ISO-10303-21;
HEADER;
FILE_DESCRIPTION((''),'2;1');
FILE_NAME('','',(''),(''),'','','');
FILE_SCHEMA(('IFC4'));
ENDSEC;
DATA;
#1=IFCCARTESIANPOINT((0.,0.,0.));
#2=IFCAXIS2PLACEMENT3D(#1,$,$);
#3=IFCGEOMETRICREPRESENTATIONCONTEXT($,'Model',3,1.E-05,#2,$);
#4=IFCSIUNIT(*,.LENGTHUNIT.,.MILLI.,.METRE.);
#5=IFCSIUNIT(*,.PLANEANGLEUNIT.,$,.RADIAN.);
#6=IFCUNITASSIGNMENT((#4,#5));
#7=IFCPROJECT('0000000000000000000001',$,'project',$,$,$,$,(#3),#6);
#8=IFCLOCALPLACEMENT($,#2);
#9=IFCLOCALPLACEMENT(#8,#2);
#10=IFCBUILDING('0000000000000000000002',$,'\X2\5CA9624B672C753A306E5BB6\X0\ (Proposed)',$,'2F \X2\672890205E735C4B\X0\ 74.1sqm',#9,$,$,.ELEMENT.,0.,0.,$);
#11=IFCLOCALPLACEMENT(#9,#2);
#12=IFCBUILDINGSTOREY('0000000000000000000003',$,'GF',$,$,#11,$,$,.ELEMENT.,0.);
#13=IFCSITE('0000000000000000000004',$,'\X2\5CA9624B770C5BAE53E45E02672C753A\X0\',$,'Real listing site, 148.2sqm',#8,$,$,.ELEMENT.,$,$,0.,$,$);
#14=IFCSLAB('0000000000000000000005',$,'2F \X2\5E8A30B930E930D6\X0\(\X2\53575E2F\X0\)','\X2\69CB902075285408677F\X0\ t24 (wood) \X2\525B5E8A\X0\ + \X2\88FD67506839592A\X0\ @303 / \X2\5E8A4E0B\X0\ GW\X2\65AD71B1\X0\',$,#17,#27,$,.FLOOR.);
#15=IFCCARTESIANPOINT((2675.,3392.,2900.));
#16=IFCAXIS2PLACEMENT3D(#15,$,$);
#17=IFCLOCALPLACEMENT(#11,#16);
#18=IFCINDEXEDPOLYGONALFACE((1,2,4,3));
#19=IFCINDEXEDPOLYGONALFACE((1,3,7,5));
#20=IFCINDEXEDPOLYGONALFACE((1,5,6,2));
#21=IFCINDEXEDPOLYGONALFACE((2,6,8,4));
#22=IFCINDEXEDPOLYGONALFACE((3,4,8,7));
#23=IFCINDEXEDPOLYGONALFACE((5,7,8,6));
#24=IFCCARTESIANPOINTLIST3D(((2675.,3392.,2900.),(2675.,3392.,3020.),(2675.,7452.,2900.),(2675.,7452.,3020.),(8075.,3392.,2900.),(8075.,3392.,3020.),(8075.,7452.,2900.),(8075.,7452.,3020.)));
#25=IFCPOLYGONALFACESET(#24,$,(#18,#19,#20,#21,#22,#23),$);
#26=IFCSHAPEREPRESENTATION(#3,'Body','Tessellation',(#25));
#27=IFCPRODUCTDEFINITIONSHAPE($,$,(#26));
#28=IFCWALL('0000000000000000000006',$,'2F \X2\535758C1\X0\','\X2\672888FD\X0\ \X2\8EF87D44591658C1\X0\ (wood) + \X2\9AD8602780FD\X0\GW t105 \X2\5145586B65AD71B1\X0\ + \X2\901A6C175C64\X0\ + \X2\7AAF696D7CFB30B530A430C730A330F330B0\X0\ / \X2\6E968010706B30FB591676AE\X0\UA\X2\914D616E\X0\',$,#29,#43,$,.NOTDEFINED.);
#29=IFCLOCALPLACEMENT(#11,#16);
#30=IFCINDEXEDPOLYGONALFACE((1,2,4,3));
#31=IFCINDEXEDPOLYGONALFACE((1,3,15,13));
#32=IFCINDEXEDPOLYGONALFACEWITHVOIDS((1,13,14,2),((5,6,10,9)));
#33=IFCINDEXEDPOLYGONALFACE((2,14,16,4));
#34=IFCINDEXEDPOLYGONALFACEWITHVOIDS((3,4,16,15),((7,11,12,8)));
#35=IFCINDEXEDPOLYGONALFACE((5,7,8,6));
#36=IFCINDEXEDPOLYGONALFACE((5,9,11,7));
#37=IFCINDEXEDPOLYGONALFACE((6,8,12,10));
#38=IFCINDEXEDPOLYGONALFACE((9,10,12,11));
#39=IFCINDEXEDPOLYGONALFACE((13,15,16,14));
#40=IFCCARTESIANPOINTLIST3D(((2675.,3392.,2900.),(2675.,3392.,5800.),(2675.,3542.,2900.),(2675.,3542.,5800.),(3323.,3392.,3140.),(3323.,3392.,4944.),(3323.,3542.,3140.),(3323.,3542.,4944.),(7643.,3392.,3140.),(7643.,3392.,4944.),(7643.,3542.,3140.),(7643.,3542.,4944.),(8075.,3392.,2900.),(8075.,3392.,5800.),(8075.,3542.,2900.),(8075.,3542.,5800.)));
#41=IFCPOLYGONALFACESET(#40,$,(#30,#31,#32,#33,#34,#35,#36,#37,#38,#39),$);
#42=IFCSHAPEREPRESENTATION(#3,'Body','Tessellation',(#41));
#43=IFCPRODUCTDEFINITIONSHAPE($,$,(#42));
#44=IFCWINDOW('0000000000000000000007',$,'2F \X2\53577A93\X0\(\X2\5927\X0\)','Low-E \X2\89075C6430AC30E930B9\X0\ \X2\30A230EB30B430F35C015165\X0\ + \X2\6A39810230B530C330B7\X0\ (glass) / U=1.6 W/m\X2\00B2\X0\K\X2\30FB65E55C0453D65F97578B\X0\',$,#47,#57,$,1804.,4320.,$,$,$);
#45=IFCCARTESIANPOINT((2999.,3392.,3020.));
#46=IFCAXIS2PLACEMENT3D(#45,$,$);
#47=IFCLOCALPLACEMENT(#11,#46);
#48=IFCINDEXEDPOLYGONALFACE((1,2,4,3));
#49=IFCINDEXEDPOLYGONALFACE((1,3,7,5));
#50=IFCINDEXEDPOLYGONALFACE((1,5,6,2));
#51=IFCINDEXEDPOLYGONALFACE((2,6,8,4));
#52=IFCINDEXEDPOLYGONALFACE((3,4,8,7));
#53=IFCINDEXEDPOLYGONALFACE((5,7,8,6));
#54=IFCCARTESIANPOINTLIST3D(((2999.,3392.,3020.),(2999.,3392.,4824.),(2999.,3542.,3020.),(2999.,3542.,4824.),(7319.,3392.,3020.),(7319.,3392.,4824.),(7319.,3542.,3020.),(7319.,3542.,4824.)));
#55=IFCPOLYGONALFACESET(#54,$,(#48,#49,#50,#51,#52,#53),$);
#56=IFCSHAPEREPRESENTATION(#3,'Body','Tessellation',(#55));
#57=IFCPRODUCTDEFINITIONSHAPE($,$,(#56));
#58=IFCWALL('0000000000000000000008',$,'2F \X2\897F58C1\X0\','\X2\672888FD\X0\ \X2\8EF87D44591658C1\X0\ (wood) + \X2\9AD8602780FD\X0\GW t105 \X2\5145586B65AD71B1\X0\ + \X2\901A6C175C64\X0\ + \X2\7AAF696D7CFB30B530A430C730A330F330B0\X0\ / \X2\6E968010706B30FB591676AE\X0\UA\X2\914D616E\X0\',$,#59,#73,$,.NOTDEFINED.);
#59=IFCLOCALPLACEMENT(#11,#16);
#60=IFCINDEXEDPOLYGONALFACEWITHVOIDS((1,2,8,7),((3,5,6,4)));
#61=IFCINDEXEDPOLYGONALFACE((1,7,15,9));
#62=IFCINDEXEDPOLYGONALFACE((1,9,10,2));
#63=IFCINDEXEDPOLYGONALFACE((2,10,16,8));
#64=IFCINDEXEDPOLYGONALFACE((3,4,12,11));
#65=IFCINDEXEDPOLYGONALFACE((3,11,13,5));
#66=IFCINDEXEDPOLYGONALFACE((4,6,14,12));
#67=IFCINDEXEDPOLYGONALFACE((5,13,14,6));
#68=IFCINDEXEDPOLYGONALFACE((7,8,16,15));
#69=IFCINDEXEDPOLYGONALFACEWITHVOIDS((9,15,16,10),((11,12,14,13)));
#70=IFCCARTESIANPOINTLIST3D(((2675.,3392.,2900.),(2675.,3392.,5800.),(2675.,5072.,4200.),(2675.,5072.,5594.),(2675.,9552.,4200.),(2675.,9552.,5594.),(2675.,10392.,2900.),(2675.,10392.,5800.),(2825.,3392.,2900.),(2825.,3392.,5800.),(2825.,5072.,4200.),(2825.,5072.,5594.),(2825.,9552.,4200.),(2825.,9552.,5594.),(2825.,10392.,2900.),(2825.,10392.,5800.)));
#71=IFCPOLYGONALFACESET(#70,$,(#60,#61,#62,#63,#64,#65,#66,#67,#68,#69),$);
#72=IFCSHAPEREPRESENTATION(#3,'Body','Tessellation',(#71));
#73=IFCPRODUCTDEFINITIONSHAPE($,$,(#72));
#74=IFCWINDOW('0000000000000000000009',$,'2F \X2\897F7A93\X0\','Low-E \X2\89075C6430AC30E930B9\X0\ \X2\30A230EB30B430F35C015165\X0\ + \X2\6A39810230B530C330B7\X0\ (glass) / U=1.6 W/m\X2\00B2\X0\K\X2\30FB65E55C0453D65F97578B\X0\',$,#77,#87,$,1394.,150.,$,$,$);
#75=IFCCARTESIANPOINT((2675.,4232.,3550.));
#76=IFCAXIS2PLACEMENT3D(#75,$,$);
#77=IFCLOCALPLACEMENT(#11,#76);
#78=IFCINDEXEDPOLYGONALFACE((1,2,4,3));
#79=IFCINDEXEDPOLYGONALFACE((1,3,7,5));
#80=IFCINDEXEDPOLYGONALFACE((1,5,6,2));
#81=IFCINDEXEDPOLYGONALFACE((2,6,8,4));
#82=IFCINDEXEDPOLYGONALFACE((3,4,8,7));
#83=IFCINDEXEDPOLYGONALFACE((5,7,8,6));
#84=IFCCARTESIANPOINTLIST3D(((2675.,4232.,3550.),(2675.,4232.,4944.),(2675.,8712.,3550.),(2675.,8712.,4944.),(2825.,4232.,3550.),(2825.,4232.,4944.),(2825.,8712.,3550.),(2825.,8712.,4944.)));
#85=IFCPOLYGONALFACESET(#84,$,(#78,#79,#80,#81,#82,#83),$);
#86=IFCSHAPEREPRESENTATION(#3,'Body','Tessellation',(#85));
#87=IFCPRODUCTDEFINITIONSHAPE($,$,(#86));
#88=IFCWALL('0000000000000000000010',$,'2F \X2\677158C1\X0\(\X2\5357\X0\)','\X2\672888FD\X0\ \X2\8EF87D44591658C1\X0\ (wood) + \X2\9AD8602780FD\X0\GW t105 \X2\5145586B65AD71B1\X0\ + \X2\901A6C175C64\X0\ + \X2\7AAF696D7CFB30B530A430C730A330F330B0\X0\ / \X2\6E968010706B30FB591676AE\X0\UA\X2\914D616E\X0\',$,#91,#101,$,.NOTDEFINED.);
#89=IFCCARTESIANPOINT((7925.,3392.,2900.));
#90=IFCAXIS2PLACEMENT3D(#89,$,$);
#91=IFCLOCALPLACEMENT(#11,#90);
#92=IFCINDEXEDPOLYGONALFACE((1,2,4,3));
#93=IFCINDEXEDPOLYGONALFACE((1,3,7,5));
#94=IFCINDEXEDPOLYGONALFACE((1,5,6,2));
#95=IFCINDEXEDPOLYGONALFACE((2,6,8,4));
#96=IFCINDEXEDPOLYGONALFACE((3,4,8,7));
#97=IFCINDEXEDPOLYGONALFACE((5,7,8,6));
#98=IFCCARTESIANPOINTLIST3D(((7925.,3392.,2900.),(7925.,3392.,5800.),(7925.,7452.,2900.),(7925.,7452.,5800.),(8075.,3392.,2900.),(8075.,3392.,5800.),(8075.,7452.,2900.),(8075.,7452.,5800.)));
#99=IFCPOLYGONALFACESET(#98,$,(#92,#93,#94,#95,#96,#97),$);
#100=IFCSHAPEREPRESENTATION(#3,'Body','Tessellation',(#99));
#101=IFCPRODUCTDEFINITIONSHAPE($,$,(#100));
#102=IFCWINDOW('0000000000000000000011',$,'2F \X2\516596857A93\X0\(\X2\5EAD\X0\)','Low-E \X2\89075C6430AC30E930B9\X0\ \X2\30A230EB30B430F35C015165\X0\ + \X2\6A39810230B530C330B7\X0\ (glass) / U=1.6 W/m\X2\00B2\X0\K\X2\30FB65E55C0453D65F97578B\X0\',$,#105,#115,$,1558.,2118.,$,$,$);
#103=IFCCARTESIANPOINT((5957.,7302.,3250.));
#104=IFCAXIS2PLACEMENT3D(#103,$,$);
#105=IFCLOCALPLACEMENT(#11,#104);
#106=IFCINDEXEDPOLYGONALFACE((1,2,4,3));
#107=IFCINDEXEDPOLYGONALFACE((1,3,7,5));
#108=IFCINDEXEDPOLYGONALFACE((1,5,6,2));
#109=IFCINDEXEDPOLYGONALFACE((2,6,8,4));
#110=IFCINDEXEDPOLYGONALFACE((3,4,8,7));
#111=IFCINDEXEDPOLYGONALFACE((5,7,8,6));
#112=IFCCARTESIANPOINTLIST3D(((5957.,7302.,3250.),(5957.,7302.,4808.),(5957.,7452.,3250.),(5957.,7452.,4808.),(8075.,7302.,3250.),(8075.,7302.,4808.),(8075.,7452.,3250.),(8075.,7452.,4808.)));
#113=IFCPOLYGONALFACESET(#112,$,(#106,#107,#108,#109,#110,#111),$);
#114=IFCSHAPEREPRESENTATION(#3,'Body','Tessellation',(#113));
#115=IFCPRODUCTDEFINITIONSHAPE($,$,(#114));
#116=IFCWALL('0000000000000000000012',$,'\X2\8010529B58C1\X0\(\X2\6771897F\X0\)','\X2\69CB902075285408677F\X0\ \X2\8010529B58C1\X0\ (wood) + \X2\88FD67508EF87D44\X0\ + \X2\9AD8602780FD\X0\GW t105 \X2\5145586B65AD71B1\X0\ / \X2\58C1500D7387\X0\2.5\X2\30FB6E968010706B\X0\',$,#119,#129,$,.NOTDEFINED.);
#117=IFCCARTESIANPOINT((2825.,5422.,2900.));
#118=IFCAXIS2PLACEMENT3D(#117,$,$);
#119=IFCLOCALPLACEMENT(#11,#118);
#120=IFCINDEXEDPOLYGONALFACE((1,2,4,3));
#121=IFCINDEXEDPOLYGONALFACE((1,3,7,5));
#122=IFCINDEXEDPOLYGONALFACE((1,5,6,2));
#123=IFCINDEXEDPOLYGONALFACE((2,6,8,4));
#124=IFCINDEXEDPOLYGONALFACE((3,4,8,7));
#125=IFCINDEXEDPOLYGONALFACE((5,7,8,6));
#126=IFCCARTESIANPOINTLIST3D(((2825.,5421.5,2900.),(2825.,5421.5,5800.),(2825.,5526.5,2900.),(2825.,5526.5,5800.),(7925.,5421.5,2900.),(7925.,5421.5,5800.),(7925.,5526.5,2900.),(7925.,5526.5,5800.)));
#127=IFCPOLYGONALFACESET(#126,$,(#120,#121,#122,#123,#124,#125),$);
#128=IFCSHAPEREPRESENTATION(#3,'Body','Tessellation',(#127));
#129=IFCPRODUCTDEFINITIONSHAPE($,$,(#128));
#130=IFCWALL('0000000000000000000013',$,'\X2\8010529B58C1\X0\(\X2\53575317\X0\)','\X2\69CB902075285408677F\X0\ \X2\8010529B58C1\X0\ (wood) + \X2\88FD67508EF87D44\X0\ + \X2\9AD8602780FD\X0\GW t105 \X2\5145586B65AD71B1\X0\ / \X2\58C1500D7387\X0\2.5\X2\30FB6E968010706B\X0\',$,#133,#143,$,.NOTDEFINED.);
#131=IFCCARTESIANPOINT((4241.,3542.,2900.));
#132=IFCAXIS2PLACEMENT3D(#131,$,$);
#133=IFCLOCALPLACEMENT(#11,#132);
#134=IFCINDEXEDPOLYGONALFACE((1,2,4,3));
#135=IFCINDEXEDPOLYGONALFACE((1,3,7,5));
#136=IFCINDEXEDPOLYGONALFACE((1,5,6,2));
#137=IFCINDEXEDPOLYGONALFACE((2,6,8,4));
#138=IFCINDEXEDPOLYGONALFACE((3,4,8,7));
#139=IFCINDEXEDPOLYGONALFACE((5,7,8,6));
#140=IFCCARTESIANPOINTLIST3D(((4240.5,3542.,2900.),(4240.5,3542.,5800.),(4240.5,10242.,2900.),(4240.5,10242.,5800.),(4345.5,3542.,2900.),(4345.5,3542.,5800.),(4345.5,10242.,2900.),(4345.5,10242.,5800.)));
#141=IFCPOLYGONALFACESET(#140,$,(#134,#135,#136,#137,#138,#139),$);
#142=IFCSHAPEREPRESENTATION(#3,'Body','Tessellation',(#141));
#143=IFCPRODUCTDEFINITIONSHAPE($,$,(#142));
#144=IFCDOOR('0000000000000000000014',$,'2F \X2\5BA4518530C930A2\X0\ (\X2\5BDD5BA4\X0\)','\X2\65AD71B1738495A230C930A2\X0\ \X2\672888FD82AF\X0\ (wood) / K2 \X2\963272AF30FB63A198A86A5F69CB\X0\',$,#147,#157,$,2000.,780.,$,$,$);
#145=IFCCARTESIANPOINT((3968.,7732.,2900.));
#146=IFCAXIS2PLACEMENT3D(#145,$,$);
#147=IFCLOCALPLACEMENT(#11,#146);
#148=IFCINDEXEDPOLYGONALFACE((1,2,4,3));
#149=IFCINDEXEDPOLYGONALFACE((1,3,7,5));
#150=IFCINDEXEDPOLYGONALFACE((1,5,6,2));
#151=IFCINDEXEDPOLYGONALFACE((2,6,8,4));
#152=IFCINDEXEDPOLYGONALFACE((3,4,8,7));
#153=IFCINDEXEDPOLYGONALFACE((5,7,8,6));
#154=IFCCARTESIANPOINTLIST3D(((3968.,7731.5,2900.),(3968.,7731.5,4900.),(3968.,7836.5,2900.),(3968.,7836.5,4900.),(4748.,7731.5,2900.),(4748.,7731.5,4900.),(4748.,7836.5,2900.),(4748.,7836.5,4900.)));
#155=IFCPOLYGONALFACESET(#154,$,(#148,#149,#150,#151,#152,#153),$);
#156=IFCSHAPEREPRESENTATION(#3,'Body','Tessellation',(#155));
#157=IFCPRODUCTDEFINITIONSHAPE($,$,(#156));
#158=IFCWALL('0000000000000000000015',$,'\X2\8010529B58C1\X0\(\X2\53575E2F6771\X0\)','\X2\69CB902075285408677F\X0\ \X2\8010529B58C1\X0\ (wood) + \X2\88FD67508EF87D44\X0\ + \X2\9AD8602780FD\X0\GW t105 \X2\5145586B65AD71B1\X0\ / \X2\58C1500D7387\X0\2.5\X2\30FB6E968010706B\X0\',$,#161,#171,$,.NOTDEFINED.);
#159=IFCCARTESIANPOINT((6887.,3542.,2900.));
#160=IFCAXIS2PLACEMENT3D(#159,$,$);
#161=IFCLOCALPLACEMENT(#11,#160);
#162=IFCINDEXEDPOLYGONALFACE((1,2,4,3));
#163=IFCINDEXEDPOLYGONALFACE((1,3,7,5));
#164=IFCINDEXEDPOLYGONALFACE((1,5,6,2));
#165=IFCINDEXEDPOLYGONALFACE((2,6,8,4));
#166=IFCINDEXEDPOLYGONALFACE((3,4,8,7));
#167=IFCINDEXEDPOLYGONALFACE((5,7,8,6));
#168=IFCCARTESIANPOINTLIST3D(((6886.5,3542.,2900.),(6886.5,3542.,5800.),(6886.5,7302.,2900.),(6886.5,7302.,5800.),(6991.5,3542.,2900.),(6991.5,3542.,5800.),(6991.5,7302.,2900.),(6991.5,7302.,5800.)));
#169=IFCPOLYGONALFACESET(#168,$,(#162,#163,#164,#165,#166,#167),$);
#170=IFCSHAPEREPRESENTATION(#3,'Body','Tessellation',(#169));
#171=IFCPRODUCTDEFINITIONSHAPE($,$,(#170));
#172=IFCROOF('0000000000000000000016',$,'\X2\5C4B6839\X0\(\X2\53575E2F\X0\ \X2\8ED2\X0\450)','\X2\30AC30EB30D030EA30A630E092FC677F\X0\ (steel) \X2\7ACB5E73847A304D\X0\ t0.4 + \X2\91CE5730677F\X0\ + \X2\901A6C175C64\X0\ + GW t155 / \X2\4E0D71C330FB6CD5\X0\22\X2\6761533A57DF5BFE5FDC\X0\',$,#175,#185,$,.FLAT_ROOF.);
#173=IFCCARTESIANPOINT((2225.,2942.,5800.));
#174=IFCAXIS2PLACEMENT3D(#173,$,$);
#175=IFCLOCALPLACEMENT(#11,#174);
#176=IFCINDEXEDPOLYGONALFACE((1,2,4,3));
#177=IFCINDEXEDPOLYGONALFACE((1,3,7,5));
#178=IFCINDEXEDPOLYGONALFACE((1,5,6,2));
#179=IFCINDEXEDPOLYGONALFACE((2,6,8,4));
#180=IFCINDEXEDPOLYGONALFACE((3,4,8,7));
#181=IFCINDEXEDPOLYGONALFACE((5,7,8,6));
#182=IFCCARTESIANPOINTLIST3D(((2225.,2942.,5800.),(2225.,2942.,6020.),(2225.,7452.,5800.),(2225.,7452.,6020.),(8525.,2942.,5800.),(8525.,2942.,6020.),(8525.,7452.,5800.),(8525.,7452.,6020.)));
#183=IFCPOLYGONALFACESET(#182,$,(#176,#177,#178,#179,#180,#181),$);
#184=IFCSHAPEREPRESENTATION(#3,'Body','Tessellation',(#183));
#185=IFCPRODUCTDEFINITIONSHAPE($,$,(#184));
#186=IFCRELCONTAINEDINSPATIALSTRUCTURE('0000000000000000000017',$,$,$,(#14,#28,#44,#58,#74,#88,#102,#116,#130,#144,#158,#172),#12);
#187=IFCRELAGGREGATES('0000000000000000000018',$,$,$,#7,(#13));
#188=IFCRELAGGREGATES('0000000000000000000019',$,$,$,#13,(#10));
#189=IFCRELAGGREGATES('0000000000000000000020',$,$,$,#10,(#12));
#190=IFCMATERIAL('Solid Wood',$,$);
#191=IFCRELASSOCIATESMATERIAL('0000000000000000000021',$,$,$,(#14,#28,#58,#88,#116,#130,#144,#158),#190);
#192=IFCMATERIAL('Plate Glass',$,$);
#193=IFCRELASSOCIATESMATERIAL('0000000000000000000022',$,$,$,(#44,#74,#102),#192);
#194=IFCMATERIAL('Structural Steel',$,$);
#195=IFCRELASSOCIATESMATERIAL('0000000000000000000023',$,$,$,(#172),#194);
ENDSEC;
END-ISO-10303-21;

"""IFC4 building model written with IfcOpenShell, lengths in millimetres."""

from ifc_helpers import new_model, si_unit, frame, frame_2d, origin, place, context, project, spatial, rectangle, extrude, material, element, fill, save


model = new_model("IFC4")

# Units and contexts
model_context = context("Model", 3, precision=1e-05, world=origin())
ifc_project = project(units=[si_unit("LENGTHUNIT", "METRE", prefix="MILLI"), si_unit("PLANEANGLEUNIT", "RADIAN")], contexts=[model_context])

# Site, building, storey
site_placement = place(None, origin())
site = spatial("IfcSite", under=ifc_project, at=site_placement, Name="岩手県宮古市本町", ObjectType="Real listing site, 148.2sqm", CompositionType="ELEMENT", RefElevation=0.0)
building_placement = place(site_placement, origin())
building = spatial("IfcBuilding", under=site, at=building_placement, Name="岩手本町の家 (Proposed)", ObjectType="2F 木造平屋 74.1sqm", CompositionType="ELEMENT", ElevationOfRefHeight=0.0, ElevationOfTerrain=0.0)
storey_placement = place(building_placement, origin())
storey = spatial("IfcBuildingStorey", under=building, at=storey_placement, Name="GF", CompositionType="ELEMENT", Elevation=0.0)

# Slab
ifc_material_1 = material(Name="Solid Wood")
slab_placement = place(storey_placement, frame((2675.0, 3392.0, 2900.0)))
element("IfcSlab", 1, at=slab_placement, inside=storey, material=ifc_material_1, Name="2F 床スラブ(南帯)", Description="構造用合板 t24 (wood) 剛床 + 製材根太 @303 / 床下 GW断熱", PredefinedType="FLOOR", context=model_context, shape_type="SweptSolid", body=[
    extrude(rectangle(XDim=5400.0, YDim=4060.0, at=frame_2d((2700.0, 2030.0))), frame((2675.0, 3392.0, 2900.0)), (0.0, 0.0, 1.0), 120.0),
])

# Walls, openings, windows
wall_1_placement = place(storey_placement, frame((2675.0, 3392.0, 2900.0)))
wall_1 = element("IfcWall", 2, at=wall_1_placement, inside=storey, material=ifc_material_1, Name="2F 南壁", Description="木製 軸組外壁 (wood) + 高性能GW t105 充填断熱 + 通気層 + 窯業系サイディング / 準耐火・外皮UA配慮", PredefinedType="NOTDEFINED", context=model_context, shape_type="SweptSolid", body=[
    extrude(rectangle(XDim=5400.0, YDim=150.0, at=frame_2d((2700.0, 75.0))), frame((2675.0, 3392.0, 2900.0)), (0.0, 0.0, 1.0), 2900.0),
])
opening_1_placement = place(storey_placement, frame((2999.0, 3392.0, 3020.0)))
opening_1 = element("IfcOpeningElement", 3, at=opening_1_placement, cuts=wall_1, PredefinedType="NOTDEFINED", context=model_context, shape_type="SweptSolid", body=[
    extrude(rectangle(XDim=4320.0, YDim=150.0, at=frame_2d((2160.0, 75.0))), frame((2999.0, 3392.0, 3020.0)), (0.0, 0.0, 1.0), 1804.0),
])
ifc_material_2 = material(Name="Plate Glass")
window_1_placement = place(storey_placement, frame((2999.0, 3392.0, 3020.0)))
window_1 = element("IfcWindow", 4, at=window_1_placement, inside=storey, material=ifc_material_2, Name="2F 南窓(大)", Description="Low-E 複層ガラス アルゴン封入 + 樹脂サッシ (glass) / U=1.6 W/m²K・日射取得型", OverallHeight=1804.0, OverallWidth=4320.0, context=model_context, shape_type="SweptSolid", body=[
    extrude(rectangle(XDim=4320.0, YDim=150.0, at=frame_2d((2160.0, 75.0))), frame((2999.0, 3392.0, 3020.0)), (0.0, 0.0, 1.0), 1804.0),
])
fill(opening_1, window_1)
wall_2_placement = place(storey_placement, frame((2675.0, 3392.0, 2900.0)))
wall_2 = element("IfcWall", 5, at=wall_2_placement, inside=storey, material=ifc_material_1, Name="2F 西壁", Description="木製 軸組外壁 (wood) + 高性能GW t105 充填断熱 + 通気層 + 窯業系サイディング / 準耐火・外皮UA配慮", PredefinedType="NOTDEFINED", context=model_context, shape_type="SweptSolid", body=[
    extrude(rectangle(XDim=150.0, YDim=7000.0, at=frame_2d((75.0, 3500.0))), frame((2675.0, 3392.0, 2900.0)), (0.0, 0.0, 1.0), 2900.0),
])
opening_2_placement = place(storey_placement, frame((2675.0, 4232.0, 3550.0)))
opening_2 = element("IfcOpeningElement", 6, at=opening_2_placement, cuts=wall_2, PredefinedType="NOTDEFINED", context=model_context, shape_type="SweptSolid", body=[
    extrude(rectangle(XDim=150.0, YDim=4480.0, at=frame_2d((75.0, 2240.0))), frame((2675.0, 4232.0, 3550.0)), (0.0, 0.0, 1.0), 1394.0),
])
window_2_placement = place(storey_placement, frame((2675.0, 4232.0, 3550.0)))
window_2 = element("IfcWindow", 7, at=window_2_placement, inside=storey, material=ifc_material_2, Name="2F 西窓", Description="Low-E 複層ガラス アルゴン封入 + 樹脂サッシ (glass) / U=1.6 W/m²K・日射取得型", OverallHeight=1394.0, OverallWidth=150.0, context=model_context, shape_type="SweptSolid", body=[
    extrude(rectangle(XDim=150.0, YDim=4480.0, at=frame_2d((75.0, 2240.0))), frame((2675.0, 4232.0, 3550.0)), (0.0, 0.0, 1.0), 1394.0),
])
fill(opening_2, window_2)
wall_3_placement = place(storey_placement, frame((7925.0, 3392.0, 2900.0)))
wall_3 = element("IfcWall", 8, at=wall_3_placement, inside=storey, material=ifc_material_1, Name="2F 東壁(南)", Description="木製 軸組外壁 (wood) + 高性能GW t105 充填断熱 + 通気層 + 窯業系サイディング / 準耐火・外皮UA配慮", PredefinedType="NOTDEFINED", context=model_context, shape_type="SweptSolid", body=[
    extrude(rectangle(XDim=150.0, YDim=4060.0, at=frame_2d((75.0, 2030.0))), frame((7925.0, 3392.0, 2900.0)), (0.0, 0.0, 1.0), 2900.0),
])
opening_3_placement = place(storey_placement, frame((5957.0, 7302.0, 3250.0)))
opening_3 = element("IfcOpeningElement", 9, at=opening_3_placement, cuts=wall_3, PredefinedType="NOTDEFINED", context=model_context, shape_type="SweptSolid", body=[
    extrude(rectangle(XDim=2118.0, YDim=150.0, at=frame_2d((1059.0, 75.0))), frame((5957.0, 7302.0, 3250.0)), (0.0, 0.0, 1.0), 1558.0),
])
window_3_placement = place(storey_placement, frame((5957.0, 7302.0, 3250.0)))
window_3 = element("IfcWindow", 10, at=window_3_placement, inside=storey, material=ifc_material_2, Name="2F 入隅窓(庭)", Description="Low-E 複層ガラス アルゴン封入 + 樹脂サッシ (glass) / U=1.6 W/m²K・日射取得型", OverallHeight=1558.0, OverallWidth=2118.0, context=model_context, shape_type="SweptSolid", body=[
    extrude(rectangle(XDim=2118.0, YDim=150.0, at=frame_2d((1059.0, 75.0))), frame((5957.0, 7302.0, 3250.0)), (0.0, 0.0, 1.0), 1558.0),
])
fill(opening_3, window_3)

# Wall
wall_4_placement = place(storey_placement, frame((2825.0, 5422.0, 2900.0)))
element("IfcWall", 11, at=wall_4_placement, inside=storey, material=ifc_material_1, Name="耐力壁(東西)", Description="構造用合板 耐力壁 (wood) + 製材軸組 + 高性能GW t105 充填断熱 / 壁倍率2.5・準耐火", PredefinedType="NOTDEFINED", context=model_context, shape_type="SweptSolid", body=[
    extrude(rectangle(XDim=5100.0, YDim=105.0, at=frame_2d((2550.0, 52.0))), frame((2825.0, 5422.0, 2900.0)), (0.0, 0.0, 1.0), 2900.0),
])

# Wall, opening, door
wall_5_placement = place(storey_placement, frame((4241.0, 3542.0, 2900.0)))
wall_5 = element("IfcWall", 12, at=wall_5_placement, inside=storey, material=ifc_material_1, Name="耐力壁(南北)", Description="構造用合板 耐力壁 (wood) + 製材軸組 + 高性能GW t105 充填断熱 / 壁倍率2.5・準耐火", PredefinedType="NOTDEFINED", context=model_context, shape_type="SweptSolid", body=[
    extrude(rectangle(XDim=105.0, YDim=6700.0, at=frame_2d((52.0, 3350.0))), frame((4241.0, 3542.0, 2900.0)), (0.0, 0.0, 1.0), 2900.0),
])
opening_4_placement = place(storey_placement, frame((3968.0, 7732.0, 2900.0)))
opening_4 = element("IfcOpeningElement", 13, at=opening_4_placement, cuts=wall_5, PredefinedType="NOTDEFINED", context=model_context, shape_type="SweptSolid", body=[
    extrude(rectangle(XDim=780.0, YDim=105.0, at=frame_2d((390.0, 52.0))), frame((3968.0, 7732.0, 2900.0)), (0.0, 0.0, 1.0), 2000.0),
])
door_placement = place(storey_placement, frame((3968.0, 7732.0, 2900.0)))
door = element("IfcDoor", 14, at=door_placement, inside=storey, material=ifc_material_1, Name="2F 室内ドア (寝室)", Description="断熱玄関ドア 木製芯 (wood) / K2 防犯・採風機構", OverallHeight=2000.0, OverallWidth=780.0, context=model_context, shape_type="SweptSolid", body=[
    extrude(rectangle(XDim=780.0, YDim=105.0, at=frame_2d((390.0, 52.0))), frame((3968.0, 7732.0, 2900.0)), (0.0, 0.0, 1.0), 2000.0),
])
fill(opening_4, door)

# Wall
wall_6_placement = place(storey_placement, frame((6887.0, 3542.0, 2900.0)))
element("IfcWall", 15, at=wall_6_placement, inside=storey, material=ifc_material_1, Name="耐力壁(南帯東)", Description="構造用合板 耐力壁 (wood) + 製材軸組 + 高性能GW t105 充填断熱 / 壁倍率2.5・準耐火", PredefinedType="NOTDEFINED", context=model_context, shape_type="SweptSolid", body=[
    extrude(rectangle(XDim=105.0, YDim=3760.0, at=frame_2d((52.0, 1880.0))), frame((6887.0, 3542.0, 2900.0)), (0.0, 0.0, 1.0), 2900.0),
])

# Roof
ifc_material_3 = material(Name="Structural Steel")
for number, where, name in (
    (16, (2225.0, 2942.0, 5800.0), "屋根(南帯 軒450)"),
):
    element("IfcRoof", number, at=place(storey_placement, frame(where)), inside=storey, material=ifc_material_3, Name=name, Description="ガルバリウム鋼板 (steel) 立平葺き t0.4 + 野地板 + 通気層 + GW t155 / 不燃・法22条区域対応", PredefinedType="FLAT_ROOF", context=model_context, shape_type="SweptSolid", body=[
        extrude(rectangle(XDim=6300.0, YDim=4510.0, at=frame_2d((3150.0, 2255.0))), frame((2225.0, 2942.0, 5800.0)), (0.0, 0.0, 1.0), 220.0),
    ])

save(model, "model.ifc")
